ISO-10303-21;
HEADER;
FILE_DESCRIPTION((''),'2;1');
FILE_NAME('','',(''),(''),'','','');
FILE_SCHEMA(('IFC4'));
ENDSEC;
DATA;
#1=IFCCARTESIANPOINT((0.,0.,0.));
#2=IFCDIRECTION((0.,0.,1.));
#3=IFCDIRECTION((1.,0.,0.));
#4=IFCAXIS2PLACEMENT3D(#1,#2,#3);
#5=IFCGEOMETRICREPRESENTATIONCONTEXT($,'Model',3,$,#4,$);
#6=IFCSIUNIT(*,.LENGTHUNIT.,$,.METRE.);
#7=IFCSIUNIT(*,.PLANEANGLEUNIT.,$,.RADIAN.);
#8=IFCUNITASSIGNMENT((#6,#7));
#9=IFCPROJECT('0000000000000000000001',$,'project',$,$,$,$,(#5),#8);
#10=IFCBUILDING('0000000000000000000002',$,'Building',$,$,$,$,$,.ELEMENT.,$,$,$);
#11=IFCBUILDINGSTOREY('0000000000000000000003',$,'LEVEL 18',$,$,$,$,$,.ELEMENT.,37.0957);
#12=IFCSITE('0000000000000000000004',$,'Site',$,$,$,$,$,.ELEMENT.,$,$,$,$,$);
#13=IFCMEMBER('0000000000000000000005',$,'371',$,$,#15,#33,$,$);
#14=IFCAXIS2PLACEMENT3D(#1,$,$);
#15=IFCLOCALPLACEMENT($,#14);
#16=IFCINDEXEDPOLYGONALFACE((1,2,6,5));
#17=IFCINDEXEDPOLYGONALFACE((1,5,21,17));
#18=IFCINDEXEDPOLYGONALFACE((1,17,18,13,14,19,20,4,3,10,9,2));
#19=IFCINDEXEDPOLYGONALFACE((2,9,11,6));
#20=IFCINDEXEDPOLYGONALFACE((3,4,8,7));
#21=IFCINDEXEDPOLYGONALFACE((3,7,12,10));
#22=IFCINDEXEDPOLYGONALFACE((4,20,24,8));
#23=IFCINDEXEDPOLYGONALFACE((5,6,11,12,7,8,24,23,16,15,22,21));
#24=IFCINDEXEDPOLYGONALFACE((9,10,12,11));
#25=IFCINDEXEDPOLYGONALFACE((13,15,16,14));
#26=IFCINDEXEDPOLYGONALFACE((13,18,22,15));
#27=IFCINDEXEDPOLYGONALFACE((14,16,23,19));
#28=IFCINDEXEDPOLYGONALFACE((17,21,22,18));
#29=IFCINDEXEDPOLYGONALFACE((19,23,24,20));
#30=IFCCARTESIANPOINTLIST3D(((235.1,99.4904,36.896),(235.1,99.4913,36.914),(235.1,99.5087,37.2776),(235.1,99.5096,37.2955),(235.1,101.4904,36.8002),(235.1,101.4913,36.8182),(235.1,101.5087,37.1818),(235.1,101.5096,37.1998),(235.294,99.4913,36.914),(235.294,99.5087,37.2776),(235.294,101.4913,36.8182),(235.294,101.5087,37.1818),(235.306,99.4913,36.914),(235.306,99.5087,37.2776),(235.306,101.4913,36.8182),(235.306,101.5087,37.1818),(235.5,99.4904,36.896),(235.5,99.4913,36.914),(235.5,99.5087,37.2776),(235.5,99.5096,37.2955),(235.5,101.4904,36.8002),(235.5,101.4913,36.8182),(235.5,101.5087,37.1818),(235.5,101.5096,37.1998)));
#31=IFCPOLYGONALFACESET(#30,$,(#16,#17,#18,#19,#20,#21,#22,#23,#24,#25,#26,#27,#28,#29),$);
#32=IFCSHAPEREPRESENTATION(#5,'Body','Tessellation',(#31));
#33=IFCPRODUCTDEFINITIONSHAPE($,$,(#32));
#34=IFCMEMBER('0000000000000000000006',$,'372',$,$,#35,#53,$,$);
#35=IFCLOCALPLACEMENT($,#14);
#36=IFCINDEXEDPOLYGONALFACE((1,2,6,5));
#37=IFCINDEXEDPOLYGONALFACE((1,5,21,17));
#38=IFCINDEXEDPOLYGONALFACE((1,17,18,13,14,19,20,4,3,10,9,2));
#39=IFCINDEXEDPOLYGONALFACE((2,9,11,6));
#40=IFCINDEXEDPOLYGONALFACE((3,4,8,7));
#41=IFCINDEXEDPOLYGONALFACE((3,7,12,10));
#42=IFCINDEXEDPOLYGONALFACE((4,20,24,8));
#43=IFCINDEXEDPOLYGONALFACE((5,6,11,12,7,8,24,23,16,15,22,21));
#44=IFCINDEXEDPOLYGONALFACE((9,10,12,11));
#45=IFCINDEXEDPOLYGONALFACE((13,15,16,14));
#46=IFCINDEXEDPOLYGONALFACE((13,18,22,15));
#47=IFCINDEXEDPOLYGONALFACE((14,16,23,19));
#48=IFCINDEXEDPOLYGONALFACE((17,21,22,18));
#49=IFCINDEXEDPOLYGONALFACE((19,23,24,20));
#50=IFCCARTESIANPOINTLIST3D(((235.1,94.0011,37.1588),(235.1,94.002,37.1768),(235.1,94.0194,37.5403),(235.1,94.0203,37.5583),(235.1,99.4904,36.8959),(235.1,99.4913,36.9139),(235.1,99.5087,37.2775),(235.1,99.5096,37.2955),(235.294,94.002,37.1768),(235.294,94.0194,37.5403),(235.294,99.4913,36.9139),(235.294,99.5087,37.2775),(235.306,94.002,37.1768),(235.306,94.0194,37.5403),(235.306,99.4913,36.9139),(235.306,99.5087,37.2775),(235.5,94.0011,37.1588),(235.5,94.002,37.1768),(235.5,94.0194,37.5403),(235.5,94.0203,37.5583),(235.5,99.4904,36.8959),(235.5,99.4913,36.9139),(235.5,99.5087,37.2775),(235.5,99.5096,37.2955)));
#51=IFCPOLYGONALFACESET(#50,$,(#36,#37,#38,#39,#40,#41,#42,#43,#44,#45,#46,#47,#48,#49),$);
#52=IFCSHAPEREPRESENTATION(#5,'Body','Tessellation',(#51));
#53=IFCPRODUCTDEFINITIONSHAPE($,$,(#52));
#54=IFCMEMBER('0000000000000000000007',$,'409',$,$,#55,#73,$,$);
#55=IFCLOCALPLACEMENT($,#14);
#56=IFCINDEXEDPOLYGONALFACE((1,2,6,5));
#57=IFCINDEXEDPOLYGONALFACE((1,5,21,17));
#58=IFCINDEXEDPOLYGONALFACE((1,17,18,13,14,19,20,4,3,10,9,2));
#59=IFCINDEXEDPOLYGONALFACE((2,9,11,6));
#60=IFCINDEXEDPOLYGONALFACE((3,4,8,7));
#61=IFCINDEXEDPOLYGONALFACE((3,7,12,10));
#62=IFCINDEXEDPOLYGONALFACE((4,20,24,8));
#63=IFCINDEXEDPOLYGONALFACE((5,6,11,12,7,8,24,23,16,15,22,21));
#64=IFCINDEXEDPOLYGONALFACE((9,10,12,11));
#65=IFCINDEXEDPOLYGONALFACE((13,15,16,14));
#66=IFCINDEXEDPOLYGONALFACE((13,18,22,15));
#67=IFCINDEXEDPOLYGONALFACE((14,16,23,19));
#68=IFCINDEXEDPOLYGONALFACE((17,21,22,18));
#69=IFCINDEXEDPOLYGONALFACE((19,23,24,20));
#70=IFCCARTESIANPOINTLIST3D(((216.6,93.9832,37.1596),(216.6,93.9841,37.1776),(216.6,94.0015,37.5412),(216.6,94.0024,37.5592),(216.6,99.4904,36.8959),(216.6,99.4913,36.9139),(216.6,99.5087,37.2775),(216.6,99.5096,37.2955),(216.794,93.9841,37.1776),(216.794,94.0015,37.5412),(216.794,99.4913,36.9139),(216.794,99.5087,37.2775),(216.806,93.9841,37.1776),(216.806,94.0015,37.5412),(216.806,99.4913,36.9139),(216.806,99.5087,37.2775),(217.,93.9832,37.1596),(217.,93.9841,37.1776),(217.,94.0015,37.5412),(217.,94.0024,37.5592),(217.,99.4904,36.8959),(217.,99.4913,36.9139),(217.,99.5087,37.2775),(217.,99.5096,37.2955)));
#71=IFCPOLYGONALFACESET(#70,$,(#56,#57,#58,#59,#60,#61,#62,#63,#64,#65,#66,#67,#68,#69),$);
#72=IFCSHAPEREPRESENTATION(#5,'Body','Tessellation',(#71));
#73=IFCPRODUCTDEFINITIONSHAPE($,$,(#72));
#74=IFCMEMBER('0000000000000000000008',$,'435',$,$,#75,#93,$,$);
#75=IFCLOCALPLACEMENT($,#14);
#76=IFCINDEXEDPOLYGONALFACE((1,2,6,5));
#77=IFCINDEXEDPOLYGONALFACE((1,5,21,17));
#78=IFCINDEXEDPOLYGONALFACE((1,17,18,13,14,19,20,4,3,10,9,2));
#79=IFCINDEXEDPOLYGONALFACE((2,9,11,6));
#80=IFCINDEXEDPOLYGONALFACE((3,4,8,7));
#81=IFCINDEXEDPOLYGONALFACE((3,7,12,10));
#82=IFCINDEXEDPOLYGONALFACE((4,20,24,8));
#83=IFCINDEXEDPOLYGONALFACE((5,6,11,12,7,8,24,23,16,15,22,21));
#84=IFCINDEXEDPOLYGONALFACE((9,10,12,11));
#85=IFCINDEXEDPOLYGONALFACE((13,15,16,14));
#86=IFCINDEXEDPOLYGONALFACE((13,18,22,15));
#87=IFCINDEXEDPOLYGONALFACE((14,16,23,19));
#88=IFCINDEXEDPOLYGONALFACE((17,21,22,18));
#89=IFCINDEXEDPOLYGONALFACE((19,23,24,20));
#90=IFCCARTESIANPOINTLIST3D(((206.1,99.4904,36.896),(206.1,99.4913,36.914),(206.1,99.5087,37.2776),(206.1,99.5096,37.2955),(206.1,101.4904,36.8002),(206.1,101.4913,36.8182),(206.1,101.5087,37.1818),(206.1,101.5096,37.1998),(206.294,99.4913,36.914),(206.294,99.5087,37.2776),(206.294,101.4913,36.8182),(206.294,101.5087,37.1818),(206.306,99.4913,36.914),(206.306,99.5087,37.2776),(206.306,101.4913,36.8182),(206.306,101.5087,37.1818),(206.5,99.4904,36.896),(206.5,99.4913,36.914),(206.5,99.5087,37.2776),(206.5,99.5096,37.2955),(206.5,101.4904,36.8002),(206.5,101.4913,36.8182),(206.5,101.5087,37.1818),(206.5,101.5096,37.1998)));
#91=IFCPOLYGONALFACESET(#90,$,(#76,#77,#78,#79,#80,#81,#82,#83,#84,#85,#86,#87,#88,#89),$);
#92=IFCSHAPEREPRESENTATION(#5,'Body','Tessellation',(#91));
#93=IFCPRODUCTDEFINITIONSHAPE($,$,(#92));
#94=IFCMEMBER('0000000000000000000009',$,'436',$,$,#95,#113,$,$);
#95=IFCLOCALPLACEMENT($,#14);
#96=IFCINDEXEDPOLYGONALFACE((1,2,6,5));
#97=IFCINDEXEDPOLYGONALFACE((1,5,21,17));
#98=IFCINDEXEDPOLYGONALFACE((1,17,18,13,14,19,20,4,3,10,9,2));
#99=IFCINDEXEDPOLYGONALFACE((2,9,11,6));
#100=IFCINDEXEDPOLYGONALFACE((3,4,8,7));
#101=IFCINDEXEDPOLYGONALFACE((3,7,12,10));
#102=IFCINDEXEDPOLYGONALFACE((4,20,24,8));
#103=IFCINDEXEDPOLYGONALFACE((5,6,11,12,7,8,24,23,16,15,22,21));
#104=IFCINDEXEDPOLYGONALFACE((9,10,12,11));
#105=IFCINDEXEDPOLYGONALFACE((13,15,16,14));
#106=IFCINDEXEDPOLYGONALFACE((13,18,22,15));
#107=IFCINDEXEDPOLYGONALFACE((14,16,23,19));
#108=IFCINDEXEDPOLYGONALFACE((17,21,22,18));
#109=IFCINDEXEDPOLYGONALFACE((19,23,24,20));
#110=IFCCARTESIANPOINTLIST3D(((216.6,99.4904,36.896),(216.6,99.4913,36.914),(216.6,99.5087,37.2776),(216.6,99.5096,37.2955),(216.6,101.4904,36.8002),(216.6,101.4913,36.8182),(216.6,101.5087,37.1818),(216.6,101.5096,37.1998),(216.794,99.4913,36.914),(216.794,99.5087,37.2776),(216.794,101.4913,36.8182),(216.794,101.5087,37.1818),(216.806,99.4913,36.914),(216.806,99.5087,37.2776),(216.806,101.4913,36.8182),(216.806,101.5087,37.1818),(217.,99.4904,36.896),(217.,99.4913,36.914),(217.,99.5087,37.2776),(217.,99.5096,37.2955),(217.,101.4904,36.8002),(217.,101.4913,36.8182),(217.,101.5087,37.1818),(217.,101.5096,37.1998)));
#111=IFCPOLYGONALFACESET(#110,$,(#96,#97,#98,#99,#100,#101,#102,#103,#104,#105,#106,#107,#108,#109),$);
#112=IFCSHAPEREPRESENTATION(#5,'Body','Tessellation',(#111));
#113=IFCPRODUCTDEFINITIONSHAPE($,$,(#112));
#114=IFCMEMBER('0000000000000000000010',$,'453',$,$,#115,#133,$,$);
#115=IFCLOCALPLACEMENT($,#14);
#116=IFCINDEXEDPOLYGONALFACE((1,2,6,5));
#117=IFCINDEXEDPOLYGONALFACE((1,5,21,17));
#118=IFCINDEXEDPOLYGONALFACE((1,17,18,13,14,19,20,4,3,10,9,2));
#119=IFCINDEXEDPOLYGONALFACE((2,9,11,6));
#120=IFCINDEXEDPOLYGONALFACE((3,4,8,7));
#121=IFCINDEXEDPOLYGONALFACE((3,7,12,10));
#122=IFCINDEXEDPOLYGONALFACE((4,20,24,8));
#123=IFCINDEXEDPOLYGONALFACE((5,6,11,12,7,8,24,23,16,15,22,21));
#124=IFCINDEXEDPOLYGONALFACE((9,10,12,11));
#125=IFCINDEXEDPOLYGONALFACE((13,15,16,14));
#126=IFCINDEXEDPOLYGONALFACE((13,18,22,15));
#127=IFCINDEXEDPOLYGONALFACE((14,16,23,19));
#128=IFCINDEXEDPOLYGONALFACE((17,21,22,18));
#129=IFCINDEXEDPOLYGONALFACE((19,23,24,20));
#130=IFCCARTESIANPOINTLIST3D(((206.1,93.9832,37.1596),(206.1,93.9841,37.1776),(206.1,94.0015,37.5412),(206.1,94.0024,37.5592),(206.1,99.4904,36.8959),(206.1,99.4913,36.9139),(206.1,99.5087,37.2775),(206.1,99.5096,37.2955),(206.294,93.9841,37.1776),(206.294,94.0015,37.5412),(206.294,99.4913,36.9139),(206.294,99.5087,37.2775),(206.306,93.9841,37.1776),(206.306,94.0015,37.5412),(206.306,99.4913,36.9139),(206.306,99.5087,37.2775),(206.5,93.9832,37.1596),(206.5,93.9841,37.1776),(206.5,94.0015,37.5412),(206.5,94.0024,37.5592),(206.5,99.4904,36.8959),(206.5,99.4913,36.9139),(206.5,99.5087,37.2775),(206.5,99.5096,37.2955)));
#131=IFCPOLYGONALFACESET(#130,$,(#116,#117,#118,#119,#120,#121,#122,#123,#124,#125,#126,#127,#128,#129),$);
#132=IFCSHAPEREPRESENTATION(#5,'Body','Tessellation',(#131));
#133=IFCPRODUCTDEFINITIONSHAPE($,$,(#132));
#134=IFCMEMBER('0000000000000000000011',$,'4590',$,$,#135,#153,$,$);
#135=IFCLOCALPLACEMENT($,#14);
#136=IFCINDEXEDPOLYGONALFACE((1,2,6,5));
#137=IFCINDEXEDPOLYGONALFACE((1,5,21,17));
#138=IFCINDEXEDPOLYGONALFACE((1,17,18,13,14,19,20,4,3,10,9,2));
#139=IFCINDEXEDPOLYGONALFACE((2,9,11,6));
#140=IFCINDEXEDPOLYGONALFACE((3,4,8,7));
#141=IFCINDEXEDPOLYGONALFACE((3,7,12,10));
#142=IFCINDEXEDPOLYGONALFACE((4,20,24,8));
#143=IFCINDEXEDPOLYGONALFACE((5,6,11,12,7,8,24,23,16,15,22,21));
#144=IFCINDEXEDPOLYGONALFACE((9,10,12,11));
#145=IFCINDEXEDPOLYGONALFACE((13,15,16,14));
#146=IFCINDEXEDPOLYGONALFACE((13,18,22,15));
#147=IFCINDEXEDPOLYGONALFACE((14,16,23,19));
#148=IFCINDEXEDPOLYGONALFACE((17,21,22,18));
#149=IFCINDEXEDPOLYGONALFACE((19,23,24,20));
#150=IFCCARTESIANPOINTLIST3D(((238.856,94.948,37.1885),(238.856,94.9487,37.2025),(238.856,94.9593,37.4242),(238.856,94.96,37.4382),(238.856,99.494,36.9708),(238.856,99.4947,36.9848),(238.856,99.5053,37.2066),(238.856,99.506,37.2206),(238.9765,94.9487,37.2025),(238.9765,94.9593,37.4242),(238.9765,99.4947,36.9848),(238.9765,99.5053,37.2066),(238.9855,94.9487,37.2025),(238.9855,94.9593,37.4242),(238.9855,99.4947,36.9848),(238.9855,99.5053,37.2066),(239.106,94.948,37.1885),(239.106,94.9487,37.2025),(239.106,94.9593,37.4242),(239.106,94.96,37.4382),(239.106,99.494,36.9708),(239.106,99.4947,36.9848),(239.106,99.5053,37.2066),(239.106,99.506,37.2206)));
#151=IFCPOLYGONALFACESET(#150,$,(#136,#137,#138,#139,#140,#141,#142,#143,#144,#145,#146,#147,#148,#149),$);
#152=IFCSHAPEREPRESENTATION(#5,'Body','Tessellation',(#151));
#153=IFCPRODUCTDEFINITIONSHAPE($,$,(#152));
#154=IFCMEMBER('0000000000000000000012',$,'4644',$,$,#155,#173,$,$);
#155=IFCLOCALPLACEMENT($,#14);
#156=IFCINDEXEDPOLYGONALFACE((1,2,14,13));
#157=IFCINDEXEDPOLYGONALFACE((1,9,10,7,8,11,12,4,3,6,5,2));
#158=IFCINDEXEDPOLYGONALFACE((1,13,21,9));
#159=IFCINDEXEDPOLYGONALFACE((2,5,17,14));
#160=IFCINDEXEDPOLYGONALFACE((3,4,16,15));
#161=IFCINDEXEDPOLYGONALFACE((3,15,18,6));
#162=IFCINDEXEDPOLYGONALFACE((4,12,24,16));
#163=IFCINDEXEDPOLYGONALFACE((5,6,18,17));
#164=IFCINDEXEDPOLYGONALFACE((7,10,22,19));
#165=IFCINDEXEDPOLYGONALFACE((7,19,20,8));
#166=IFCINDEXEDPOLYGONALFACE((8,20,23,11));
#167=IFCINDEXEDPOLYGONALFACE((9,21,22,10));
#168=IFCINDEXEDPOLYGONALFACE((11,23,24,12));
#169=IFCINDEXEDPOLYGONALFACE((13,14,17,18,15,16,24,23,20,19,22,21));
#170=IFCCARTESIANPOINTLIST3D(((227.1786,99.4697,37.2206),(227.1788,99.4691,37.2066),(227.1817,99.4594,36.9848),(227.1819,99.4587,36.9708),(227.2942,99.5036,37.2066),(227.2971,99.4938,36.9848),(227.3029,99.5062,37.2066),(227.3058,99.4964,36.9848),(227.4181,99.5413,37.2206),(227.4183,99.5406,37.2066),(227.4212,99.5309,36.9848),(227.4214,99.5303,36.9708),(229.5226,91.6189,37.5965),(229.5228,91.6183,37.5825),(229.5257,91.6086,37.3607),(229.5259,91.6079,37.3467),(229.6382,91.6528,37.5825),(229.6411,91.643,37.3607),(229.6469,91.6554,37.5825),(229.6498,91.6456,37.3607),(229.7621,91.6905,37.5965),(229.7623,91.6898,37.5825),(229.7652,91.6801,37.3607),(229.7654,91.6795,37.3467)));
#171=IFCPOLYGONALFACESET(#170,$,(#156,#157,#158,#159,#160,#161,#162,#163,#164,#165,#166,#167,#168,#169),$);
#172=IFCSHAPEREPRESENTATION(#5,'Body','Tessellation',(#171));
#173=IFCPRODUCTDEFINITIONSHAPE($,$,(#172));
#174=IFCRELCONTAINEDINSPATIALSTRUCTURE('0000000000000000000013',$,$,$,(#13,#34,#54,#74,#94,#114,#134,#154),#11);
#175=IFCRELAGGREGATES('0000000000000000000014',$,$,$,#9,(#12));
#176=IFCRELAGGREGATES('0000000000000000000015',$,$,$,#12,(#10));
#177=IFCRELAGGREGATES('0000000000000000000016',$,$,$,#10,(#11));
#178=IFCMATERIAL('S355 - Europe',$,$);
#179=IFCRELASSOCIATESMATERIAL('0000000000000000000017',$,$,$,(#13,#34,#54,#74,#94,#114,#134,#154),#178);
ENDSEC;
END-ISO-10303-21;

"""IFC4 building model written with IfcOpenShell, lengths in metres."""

from ifc_helpers import new_model, si_unit, frame, origin_with_axes, origin_2d_with_axis, place, context, project, spatial, i_section, extrude, material, material_profile, profile_set, profile_usage, element, save


model = new_model("IFC4")

# Units and contexts
model_context = context("Model", 3, world=origin_with_axes())
ifc_project = project(units=[si_unit("LENGTHUNIT", "METRE"), si_unit("PLANEANGLEUNIT", "RADIAN")], contexts=[model_context])

# Site, building, storey
site = spatial("IfcSite", under=ifc_project, Name="Site", CompositionType="ELEMENT")
building = spatial("IfcBuilding", under=site, Name="Building", CompositionType="ELEMENT")
storey = spatial("IfcBuildingStorey", under=building, Name="LEVEL 18", CompositionType="ELEMENT", Elevation=37.0957)

# Shared definitions
ifc_material = material(Name="S355 - Europe")

# Members
ifc_material_profile_1 = material_profile(ifc_material, i_section(OverallWidth=0.4, OverallDepth=0.4, WebThickness=0.012, FlangeThickness=0.018, at=origin_2d_with_axis()))
ifc_profile_set_1 = profile_set([ifc_material_profile_1])
ifc_profile_usage_1 = profile_usage(ifc_profile_set_1, cardinal=10)
member_1_placement = place(None, frame((235.3, 101.5, 37.0), z_axis=(0.0, -0.998856, 0.047828), x_axis=(1.0, 0.0, 0.0)))
element("IfcMember", 1, at=member_1_placement, inside=storey, material=ifc_profile_usage_1, Name="371", context=model_context, shape_type="SweptSolid", body=[
    extrude(i_section(OverallWidth=0.4, OverallDepth=0.4, WebThickness=0.012, FlangeThickness=0.018, at=origin_2d_with_axis()), origin_with_axes(), (0.0, 0.0, 1.0), 2.0023),
])
ifc_material_profile_2 = material_profile(ifc_material, i_section(OverallWidth=0.4, OverallDepth=0.4, WebThickness=0.012, FlangeThickness=0.018, at=origin_2d_with_axis()))
ifc_profile_set_2 = profile_set([ifc_material_profile_2])
ifc_profile_usage_2 = profile_usage(ifc_profile_set_2, cardinal=10)
member_2_placement = place(None, frame((235.3, 99.5, 37.0957), z_axis=(0.0, -0.998856, 0.047828), x_axis=(1.0, 0.0, 0.0)))
element("IfcMember", 2, at=member_2_placement, inside=storey, material=ifc_profile_usage_2, Name="372", context=model_context, shape_type="SweptSolid", body=[
    extrude(i_section(OverallWidth=0.4, OverallDepth=0.4, WebThickness=0.012, FlangeThickness=0.018, at=origin_2d_with_axis()), origin_with_axes(), (0.0, 0.0, 1.0), 5.4956),
])
ifc_material_profile_3 = material_profile(ifc_material, i_section(OverallWidth=0.4, OverallDepth=0.4, WebThickness=0.012, FlangeThickness=0.018, at=origin_2d_with_axis()))
ifc_profile_set_3 = profile_set([ifc_material_profile_3])
ifc_profile_usage_3 = profile_usage(ifc_profile_set_3, cardinal=10)
member_3_placement = place(None, frame((216.8, 99.5, 37.0957), z_axis=(0.0, -0.998856, 0.047828), x_axis=(1.0, 0.0, 0.0)))
element("IfcMember", 3, at=member_3_placement, inside=storey, material=ifc_profile_usage_3, Name="409", context=model_context, shape_type="SweptSolid", body=[
    extrude(i_section(OverallWidth=0.4, OverallDepth=0.4, WebThickness=0.012, FlangeThickness=0.018, at=origin_2d_with_axis()), origin_with_axes(), (0.0, 0.0, 1.0), 5.5135),
])
ifc_material_profile_4 = material_profile(ifc_material, i_section(OverallWidth=0.4, OverallDepth=0.4, WebThickness=0.012, FlangeThickness=0.018, at=origin_2d_with_axis()))
ifc_profile_set_4 = profile_set([ifc_material_profile_4])
ifc_profile_usage_4 = profile_usage(ifc_profile_set_4, cardinal=10)
member_4_placement = place(None, frame((206.3, 101.5, 37.0), z_axis=(0.0, -0.998856, 0.047828), x_axis=(1.0, 0.0, 0.0)))
element("IfcMember", 4, at=member_4_placement, inside=storey, material=ifc_profile_usage_4, Name="435", context=model_context, shape_type="SweptSolid", body=[
    extrude(i_section(OverallWidth=0.4, OverallDepth=0.4, WebThickness=0.012, FlangeThickness=0.018, at=origin_2d_with_axis()), origin_with_axes(), (0.0, 0.0, 1.0), 2.0023),
])
ifc_material_profile_5 = material_profile(ifc_material, i_section(OverallWidth=0.4, OverallDepth=0.4, WebThickness=0.012, FlangeThickness=0.018, at=origin_2d_with_axis()))
ifc_profile_set_5 = profile_set([ifc_material_profile_5])
ifc_profile_usage_5 = profile_usage(ifc_profile_set_5, cardinal=10)
member_5_placement = place(None, frame((216.8, 101.5, 37.0), z_axis=(0.0, -0.998856, 0.047828), x_axis=(1.0, 0.0, 0.0)))
element("IfcMember", 5, at=member_5_placement, inside=storey, material=ifc_profile_usage_5, Name="436", context=model_context, shape_type="SweptSolid", body=[
    extrude(i_section(OverallWidth=0.4, OverallDepth=0.4, WebThickness=0.012, FlangeThickness=0.018, at=origin_2d_with_axis()), origin_with_axes(), (0.0, 0.0, 1.0), 2.0023),
])
ifc_material_profile_6 = material_profile(ifc_material, i_section(OverallWidth=0.4, OverallDepth=0.4, WebThickness=0.012, FlangeThickness=0.018, at=origin_2d_with_axis()))
ifc_profile_set_6 = profile_set([ifc_material_profile_6])
ifc_profile_usage_6 = profile_usage(ifc_profile_set_6, cardinal=10)
member_6_placement = place(None, frame((206.3, 93.9928, 37.3594), z_axis=(0.0, 0.998856, -0.047828), x_axis=(-1.0, 0.0, 0.0)))
element("IfcMember", 6, at=member_6_placement, inside=storey, material=ifc_profile_usage_6, Name="453", context=model_context, shape_type="SweptSolid", body=[
    extrude(i_section(OverallWidth=0.4, OverallDepth=0.4, WebThickness=0.012, FlangeThickness=0.018, at=origin_2d_with_axis()), origin_with_axes(), (0.0, 0.0, 1.0), 5.5135),
])
ifc_material_profile_7 = material_profile(ifc_material, i_section(OverallWidth=0.25, OverallDepth=0.25, WebThickness=0.009, FlangeThickness=0.014, at=origin_2d_with_axis()))
ifc_profile_set_7 = profile_set([ifc_material_profile_7])
ifc_profile_usage_7 = profile_usage(ifc_profile_set_7, cardinal=10)
member_7_placement = place(None, frame((238.981, 99.5, 37.0957), z_axis=(0.0, -0.998856, 0.047828), x_axis=(1.0, 0.0, 0.0)))
element("IfcMember", 7, at=member_7_placement, inside=storey, material=ifc_profile_usage_7, Name="4590", context=model_context, shape_type="SweptSolid", body=[
    extrude(i_section(OverallWidth=0.25, OverallDepth=0.25, WebThickness=0.009, FlangeThickness=0.014, at=origin_2d_with_axis()), origin_with_axes(), (0.0, 0.0, 1.0), 4.5512),
])
ifc_material_profile_8 = material_profile(ifc_material, i_section(OverallWidth=0.25, OverallDepth=0.25, WebThickness=0.009, FlangeThickness=0.014, at=origin_2d_with_axis()))
ifc_profile_set_8 = profile_set([ifc_material_profile_8])
ifc_profile_usage_8 = profile_usage(ifc_profile_set_8, cardinal=10)
member_8_placement = place(None, frame((229.644, 91.6492, 37.4716), z_axis=(-0.285788, 0.957196, -0.045831), x_axis=(-0.958203, -0.286089, 0.0)))
element("IfcMember", 8, at=member_8_placement, inside=storey, material=ifc_profile_usage_8, Name="4644", context=model_context, shape_type="SweptSolid", body=[
    extrude(i_section(OverallWidth=0.25, OverallDepth=0.25, WebThickness=0.009, FlangeThickness=0.014, at=origin_2d_with_axis()), origin_with_axes(), (0.0, 0.0, 1.0), 8.2019),
])

save(model, "model.ifc")
